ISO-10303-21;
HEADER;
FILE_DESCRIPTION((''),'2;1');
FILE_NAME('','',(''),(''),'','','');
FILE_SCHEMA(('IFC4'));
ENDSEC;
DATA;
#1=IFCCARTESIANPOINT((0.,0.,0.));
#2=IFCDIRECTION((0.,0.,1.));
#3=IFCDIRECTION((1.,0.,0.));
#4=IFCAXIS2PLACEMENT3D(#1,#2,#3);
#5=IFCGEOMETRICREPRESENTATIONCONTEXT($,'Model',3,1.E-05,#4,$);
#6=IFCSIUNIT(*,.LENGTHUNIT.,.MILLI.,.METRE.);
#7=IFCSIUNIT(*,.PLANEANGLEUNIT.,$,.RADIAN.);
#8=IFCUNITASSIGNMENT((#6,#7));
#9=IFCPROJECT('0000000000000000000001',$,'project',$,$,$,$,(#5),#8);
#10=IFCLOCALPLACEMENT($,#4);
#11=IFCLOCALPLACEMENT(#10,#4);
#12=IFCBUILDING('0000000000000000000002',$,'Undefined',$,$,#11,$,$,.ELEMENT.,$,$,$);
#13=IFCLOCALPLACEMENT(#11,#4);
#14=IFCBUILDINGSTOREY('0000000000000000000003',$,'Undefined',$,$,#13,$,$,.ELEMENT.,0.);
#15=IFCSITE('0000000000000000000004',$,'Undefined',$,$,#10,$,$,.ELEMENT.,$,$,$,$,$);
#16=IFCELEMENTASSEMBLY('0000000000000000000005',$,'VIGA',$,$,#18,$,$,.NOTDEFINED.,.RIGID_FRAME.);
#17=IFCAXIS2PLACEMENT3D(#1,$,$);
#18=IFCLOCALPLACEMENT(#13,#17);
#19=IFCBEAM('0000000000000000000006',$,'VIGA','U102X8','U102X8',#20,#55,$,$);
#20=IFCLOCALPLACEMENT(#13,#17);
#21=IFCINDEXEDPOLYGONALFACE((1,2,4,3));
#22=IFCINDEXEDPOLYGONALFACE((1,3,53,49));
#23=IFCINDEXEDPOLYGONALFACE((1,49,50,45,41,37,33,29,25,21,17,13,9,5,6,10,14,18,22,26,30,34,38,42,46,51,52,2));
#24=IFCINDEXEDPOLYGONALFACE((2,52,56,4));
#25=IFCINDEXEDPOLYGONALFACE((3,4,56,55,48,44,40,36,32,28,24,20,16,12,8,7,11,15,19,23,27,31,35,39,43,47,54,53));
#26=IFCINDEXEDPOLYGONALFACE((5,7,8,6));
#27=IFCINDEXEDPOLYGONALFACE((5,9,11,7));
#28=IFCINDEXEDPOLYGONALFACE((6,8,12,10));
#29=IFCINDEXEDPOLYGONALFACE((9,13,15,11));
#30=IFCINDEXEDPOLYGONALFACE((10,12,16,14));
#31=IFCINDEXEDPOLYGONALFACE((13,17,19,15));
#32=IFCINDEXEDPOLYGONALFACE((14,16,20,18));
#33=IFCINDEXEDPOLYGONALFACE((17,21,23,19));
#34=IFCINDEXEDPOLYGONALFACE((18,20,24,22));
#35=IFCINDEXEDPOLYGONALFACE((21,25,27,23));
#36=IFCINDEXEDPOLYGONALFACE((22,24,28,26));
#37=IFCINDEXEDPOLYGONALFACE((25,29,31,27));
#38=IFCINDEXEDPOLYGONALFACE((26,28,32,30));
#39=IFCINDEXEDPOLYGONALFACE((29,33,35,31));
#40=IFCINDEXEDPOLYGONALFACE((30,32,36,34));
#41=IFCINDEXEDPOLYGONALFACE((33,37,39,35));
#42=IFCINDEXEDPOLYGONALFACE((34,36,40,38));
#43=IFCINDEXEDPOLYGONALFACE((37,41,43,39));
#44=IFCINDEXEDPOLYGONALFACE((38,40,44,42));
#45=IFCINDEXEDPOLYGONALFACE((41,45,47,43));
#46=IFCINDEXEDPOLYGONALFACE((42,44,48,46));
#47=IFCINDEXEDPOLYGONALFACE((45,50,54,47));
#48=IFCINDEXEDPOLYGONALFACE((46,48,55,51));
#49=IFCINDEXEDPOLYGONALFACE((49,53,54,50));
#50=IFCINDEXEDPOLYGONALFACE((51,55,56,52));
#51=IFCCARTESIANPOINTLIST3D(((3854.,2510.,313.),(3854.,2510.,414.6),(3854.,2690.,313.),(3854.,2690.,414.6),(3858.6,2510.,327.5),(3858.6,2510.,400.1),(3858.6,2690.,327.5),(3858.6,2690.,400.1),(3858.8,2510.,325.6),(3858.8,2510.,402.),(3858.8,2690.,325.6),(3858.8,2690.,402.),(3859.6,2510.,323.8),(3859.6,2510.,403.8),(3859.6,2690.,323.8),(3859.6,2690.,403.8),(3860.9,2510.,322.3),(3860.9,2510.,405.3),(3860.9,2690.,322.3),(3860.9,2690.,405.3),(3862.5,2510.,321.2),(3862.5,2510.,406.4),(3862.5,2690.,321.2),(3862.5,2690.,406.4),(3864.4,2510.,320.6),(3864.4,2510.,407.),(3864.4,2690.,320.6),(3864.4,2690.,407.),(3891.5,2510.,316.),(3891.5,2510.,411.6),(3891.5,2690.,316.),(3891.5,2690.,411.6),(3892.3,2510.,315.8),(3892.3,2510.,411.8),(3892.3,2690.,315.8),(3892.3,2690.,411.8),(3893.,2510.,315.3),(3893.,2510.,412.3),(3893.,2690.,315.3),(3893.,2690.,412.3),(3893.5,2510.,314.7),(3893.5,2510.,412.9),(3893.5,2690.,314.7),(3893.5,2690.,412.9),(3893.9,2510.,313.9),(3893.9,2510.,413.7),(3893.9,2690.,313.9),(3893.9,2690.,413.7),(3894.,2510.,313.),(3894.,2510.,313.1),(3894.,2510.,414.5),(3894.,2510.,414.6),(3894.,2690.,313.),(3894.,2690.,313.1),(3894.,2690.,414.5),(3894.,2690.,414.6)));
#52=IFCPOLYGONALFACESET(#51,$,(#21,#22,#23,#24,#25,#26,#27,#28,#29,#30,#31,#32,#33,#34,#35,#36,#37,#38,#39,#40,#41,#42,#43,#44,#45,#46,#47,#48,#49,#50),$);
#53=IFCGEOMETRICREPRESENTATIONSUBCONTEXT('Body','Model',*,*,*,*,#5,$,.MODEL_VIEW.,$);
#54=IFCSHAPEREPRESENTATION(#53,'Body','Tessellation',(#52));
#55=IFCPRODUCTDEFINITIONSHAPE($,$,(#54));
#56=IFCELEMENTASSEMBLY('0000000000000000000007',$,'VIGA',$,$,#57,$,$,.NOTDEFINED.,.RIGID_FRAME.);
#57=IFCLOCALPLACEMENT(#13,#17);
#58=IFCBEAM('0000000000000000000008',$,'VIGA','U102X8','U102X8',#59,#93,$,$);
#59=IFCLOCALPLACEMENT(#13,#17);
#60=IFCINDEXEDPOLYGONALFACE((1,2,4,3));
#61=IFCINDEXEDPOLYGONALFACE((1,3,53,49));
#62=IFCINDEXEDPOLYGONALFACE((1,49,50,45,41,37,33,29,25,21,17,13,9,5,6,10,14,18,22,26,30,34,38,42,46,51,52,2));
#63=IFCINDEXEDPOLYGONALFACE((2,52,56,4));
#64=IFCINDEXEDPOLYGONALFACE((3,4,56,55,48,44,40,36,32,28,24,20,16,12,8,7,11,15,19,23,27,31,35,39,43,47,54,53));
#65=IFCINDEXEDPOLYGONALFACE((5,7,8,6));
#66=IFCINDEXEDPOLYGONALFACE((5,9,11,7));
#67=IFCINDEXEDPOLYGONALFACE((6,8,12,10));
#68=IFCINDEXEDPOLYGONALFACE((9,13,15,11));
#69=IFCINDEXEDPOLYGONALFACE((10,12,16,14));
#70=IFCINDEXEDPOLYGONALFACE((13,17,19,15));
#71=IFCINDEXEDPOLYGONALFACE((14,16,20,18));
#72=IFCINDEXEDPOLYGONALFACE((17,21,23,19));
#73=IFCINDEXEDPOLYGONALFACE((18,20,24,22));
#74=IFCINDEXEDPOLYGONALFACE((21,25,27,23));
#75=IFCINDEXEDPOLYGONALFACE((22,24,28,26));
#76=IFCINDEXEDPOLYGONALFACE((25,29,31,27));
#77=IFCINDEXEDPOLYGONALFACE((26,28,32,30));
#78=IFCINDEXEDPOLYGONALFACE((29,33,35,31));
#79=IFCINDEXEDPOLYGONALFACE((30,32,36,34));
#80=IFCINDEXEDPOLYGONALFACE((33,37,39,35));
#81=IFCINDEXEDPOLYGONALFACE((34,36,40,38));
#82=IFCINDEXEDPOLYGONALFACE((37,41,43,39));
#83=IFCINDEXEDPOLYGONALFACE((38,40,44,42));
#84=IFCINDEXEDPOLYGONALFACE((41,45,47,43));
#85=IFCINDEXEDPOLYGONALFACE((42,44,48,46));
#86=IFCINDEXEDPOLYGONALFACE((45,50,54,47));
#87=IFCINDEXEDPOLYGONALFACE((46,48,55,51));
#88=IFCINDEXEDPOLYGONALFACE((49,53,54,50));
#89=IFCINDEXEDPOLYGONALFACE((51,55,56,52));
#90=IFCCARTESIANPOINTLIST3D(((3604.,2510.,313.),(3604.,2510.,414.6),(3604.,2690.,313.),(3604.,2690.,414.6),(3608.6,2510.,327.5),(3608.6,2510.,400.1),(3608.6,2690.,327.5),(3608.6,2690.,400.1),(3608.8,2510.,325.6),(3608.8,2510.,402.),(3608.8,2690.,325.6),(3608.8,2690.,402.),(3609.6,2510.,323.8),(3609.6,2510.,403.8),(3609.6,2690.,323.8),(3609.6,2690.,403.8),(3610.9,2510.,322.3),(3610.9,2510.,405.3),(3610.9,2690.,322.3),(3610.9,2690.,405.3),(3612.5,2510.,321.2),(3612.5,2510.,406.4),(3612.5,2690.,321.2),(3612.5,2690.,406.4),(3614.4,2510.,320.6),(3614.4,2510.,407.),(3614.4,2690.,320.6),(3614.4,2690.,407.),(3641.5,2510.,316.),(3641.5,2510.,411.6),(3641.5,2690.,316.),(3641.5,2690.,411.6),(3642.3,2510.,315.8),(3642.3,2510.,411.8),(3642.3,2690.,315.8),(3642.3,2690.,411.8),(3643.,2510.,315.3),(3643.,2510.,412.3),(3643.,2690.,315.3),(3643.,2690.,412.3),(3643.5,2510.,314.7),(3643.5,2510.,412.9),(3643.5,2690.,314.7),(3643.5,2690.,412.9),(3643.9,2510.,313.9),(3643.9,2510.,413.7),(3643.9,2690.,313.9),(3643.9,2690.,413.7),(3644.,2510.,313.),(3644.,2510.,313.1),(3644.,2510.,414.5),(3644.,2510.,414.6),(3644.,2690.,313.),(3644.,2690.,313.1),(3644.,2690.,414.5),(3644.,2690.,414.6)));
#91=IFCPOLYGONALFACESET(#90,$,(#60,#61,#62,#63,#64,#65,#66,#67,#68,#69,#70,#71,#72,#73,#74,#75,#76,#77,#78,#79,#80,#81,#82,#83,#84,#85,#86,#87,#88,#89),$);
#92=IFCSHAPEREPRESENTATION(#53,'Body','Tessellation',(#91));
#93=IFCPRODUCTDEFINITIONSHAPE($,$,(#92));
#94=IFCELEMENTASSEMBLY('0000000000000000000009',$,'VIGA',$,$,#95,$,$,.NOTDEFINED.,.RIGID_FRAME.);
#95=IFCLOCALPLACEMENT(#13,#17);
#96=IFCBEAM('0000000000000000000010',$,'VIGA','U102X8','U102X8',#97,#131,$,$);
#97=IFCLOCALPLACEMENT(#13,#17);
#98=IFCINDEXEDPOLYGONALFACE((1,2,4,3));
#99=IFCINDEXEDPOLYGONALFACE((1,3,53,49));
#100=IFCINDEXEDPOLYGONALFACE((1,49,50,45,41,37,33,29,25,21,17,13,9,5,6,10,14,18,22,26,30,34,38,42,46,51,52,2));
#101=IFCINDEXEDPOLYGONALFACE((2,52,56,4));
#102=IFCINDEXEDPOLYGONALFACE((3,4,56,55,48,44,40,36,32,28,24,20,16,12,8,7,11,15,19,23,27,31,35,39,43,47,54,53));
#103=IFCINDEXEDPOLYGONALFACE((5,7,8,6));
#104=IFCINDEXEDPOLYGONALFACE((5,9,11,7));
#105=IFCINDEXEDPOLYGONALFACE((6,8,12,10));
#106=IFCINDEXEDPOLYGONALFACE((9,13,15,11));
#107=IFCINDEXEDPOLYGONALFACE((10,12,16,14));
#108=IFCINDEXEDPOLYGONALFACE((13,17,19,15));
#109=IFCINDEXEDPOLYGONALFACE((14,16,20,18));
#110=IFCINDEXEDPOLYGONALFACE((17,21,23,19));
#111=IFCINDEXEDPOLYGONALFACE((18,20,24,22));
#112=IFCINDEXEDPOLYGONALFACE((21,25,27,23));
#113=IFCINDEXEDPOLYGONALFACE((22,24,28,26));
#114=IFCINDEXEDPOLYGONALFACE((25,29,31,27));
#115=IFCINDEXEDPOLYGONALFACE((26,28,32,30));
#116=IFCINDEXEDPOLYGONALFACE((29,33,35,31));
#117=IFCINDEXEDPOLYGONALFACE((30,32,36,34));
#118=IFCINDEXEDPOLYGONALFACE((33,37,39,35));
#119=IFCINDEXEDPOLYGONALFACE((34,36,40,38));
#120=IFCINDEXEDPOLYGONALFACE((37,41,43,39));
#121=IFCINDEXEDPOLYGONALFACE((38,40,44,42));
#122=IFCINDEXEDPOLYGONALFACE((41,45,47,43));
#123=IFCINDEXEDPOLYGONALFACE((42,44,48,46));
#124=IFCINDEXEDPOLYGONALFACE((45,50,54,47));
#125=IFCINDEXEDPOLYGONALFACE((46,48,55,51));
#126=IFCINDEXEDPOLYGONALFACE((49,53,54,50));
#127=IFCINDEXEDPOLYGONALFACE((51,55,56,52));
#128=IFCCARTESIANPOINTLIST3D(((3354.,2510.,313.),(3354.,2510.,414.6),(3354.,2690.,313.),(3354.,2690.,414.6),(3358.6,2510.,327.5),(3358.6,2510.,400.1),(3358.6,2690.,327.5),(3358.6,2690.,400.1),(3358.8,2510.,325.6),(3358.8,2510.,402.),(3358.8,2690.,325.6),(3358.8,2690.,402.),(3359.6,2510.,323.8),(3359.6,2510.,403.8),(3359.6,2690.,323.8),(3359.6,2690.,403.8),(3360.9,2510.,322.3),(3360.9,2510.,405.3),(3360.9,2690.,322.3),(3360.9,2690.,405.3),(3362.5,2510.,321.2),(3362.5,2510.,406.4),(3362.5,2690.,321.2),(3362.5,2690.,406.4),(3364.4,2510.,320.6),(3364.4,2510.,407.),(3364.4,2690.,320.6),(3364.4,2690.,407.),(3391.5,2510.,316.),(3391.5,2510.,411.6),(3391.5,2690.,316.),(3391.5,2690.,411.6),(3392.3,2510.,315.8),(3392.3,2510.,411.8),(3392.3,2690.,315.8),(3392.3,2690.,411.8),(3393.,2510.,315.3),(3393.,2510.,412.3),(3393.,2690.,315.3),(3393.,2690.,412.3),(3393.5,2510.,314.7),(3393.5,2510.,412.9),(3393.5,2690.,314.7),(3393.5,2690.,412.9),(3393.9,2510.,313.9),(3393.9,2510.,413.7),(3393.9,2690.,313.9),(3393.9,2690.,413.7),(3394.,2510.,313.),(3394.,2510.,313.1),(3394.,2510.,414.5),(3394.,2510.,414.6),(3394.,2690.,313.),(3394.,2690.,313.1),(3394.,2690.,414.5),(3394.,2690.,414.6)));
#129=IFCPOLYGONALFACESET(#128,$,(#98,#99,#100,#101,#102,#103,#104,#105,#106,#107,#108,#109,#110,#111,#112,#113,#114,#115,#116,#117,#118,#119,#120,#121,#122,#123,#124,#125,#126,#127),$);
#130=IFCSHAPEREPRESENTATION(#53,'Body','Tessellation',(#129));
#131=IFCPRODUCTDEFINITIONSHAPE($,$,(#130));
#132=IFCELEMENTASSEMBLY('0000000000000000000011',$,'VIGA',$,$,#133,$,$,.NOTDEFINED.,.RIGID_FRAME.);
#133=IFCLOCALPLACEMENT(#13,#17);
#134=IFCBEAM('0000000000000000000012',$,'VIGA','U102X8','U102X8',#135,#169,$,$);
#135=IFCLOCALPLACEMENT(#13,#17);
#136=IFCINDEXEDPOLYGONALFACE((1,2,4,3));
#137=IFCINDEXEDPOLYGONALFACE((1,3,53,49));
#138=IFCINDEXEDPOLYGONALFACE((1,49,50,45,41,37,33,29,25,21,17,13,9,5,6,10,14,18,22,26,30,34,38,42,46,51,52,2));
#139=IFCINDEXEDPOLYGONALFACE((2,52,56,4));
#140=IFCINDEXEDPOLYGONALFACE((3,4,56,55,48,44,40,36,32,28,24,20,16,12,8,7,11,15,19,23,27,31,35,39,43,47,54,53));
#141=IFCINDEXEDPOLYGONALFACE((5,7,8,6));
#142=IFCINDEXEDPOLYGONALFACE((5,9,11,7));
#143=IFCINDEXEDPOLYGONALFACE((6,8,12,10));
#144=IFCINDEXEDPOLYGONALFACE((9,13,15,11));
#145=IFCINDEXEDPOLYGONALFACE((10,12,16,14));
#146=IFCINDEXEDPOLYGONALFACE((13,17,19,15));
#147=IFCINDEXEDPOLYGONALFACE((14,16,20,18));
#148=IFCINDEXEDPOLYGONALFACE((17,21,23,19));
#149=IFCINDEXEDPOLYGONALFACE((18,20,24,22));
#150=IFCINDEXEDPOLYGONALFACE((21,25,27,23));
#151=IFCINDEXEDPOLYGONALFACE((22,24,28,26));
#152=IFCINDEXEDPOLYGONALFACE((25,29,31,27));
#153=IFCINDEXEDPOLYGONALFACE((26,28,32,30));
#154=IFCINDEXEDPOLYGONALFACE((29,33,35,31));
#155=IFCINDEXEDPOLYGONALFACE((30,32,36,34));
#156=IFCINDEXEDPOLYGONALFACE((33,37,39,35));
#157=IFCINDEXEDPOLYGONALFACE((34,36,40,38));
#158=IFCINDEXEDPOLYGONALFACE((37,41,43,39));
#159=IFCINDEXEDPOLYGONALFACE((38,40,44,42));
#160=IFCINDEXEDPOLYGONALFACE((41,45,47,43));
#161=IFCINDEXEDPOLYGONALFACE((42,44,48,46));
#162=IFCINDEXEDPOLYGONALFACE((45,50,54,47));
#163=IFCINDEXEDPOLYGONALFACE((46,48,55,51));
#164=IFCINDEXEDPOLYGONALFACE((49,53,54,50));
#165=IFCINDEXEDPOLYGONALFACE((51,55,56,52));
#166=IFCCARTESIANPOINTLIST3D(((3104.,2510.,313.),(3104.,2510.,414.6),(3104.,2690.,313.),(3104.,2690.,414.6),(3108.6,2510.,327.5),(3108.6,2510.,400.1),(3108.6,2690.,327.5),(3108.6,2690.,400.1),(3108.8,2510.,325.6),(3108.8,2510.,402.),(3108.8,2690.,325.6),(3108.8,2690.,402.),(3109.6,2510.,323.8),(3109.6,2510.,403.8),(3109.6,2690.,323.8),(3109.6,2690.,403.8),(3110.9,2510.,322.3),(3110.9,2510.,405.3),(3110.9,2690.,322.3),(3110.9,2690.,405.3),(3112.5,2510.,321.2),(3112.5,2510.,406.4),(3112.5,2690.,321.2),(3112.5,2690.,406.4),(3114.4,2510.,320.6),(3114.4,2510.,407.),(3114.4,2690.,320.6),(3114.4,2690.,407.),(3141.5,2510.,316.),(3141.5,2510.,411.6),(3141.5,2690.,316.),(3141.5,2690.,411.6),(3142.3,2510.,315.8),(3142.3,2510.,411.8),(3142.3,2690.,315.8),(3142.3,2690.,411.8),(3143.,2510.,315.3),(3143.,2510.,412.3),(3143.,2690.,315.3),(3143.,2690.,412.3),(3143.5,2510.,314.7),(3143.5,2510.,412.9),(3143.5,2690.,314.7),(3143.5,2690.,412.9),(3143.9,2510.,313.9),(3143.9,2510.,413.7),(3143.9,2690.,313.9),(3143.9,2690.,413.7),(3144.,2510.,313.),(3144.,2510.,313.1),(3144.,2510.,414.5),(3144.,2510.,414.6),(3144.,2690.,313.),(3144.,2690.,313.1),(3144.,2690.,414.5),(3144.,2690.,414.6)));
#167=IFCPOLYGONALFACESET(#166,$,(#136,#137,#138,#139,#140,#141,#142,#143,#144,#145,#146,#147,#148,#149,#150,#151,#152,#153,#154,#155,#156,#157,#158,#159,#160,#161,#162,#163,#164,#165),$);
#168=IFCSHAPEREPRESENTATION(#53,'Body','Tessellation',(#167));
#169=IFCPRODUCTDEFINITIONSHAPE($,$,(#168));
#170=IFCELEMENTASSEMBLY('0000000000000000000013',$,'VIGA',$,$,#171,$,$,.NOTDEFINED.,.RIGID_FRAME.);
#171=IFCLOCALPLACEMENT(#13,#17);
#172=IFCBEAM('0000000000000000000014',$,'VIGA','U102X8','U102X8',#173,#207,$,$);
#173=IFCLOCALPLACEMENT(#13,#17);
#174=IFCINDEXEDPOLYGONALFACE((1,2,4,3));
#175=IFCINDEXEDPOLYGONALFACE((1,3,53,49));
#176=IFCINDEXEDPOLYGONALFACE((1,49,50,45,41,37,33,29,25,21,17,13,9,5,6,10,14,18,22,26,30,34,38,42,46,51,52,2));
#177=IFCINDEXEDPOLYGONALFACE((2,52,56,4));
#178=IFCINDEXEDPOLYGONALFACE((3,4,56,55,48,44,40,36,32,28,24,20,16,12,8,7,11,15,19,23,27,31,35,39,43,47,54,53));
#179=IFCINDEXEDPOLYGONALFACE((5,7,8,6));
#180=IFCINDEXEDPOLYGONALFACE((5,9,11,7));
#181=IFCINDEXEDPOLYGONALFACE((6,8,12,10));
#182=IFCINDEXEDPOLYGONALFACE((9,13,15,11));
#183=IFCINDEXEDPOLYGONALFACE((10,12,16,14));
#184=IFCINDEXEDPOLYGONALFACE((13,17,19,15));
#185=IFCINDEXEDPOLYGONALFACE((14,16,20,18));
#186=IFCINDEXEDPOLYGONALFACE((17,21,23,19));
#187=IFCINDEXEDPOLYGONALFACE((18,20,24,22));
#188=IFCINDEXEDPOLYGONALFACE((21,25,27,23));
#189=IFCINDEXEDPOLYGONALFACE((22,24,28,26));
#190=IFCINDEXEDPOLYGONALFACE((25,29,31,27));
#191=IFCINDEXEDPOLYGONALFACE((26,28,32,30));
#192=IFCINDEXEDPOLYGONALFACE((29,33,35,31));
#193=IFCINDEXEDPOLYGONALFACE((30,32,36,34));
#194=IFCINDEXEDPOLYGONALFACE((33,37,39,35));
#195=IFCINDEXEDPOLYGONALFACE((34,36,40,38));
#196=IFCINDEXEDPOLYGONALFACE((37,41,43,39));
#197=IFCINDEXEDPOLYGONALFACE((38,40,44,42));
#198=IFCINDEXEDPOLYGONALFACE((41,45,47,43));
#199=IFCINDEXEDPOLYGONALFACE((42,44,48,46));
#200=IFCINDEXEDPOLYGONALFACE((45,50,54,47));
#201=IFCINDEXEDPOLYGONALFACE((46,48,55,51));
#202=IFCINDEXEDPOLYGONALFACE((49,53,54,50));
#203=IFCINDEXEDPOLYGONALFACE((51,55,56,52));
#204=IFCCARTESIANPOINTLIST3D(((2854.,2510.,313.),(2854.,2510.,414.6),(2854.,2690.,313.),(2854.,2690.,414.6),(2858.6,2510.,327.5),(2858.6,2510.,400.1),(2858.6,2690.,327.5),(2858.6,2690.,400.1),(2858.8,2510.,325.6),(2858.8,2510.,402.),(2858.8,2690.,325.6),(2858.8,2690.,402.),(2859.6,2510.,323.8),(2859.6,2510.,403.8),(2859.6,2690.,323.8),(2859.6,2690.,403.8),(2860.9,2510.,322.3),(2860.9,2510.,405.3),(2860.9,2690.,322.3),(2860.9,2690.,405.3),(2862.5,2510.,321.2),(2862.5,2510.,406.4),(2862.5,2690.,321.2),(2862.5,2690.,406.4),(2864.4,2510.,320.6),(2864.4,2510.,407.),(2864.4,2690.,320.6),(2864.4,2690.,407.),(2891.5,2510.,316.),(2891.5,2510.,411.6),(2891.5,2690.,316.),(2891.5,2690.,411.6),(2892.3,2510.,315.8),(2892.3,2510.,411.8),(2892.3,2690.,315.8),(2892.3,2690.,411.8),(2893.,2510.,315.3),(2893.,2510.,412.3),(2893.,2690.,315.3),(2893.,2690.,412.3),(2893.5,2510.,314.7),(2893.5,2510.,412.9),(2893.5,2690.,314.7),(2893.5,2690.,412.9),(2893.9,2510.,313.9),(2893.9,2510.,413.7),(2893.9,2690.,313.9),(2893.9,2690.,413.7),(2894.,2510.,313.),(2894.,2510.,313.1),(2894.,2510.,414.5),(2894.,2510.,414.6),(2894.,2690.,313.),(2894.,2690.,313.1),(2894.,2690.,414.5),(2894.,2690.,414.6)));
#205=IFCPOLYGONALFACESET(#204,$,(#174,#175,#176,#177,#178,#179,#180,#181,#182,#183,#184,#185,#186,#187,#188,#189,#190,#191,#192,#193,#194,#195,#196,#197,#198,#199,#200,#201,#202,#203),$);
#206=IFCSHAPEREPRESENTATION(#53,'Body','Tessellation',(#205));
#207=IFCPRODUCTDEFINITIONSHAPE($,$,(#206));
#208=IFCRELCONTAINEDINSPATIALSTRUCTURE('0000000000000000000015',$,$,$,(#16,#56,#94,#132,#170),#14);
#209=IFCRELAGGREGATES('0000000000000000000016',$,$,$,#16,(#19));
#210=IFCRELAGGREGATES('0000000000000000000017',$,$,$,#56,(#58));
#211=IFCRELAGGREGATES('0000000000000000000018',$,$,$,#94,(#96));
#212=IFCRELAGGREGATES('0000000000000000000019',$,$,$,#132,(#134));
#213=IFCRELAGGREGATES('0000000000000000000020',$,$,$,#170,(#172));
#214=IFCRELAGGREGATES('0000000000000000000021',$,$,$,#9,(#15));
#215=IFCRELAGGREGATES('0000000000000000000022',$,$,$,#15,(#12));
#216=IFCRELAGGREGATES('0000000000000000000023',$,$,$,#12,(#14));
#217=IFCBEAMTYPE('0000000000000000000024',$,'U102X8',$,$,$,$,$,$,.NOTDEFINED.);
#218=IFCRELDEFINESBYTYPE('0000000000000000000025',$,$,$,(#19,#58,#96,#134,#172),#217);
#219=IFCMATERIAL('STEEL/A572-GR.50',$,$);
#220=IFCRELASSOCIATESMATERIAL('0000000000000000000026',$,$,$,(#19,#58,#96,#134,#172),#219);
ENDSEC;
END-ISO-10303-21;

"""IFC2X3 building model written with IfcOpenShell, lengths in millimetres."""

from ifc_helpers import new_model, si_unit, frame, origin_with_axes, origin_2d_with_axis, place, context, subcontext, project, spatial, u_section, extrude, material, type_object, element, aggregate, save


model = new_model("IFC2X3")

# Units and contexts
model_context = context("Model", 3, precision=1e-05, world=origin_with_axes())
body_context = subcontext(model_context, "Body", "Model", "MODEL_VIEW")
ifc_project = project(units=[si_unit("LENGTHUNIT", "METRE", prefix="MILLI"), si_unit("PLANEANGLEUNIT", "RADIAN")], contexts=[model_context])

# Site, building, storey
site_placement = place(None, origin_with_axes())
site = spatial("IfcSite", under=ifc_project, at=site_placement, Name="Undefined", CompositionType="ELEMENT")
building_placement = place(site_placement, origin_with_axes())
building = spatial("IfcBuilding", under=site, at=building_placement, Name="Undefined", CompositionType="ELEMENT")
storey_placement = place(building_placement, origin_with_axes())
storey = spatial("IfcBuildingStorey", under=building, at=storey_placement, Name="Undefined", CompositionType="ELEMENT", Elevation=0.0)

# Element assemblies, beams
ifc_material_1 = material(Name="STEEL/A572-GR.50")
beam_type_1 = type_object("IfcBeamType", Name="U102X8", PredefinedType="NOTDEFINED")
assembly_1_placement = place(storey_placement, origin_with_axes())
assembly_1 = element("IfcElementAssembly", 1, at=assembly_1_placement, inside=storey, Name="VIGA", AssemblyPlace="NOTDEFINED", PredefinedType="RIGID_FRAME")
beam_1_placement = place(assembly_1_placement, frame((3874.0, 2510.0, 363.8), z_axis=(0.0, 0.0, 1.0), x_axis=(0.0, 1.0, 0.0)))
beam_1 = element("IfcBeam", 2, at=beam_1_placement, type_object=beam_type_1, material=ifc_material_1, Name="VIGA", Description="U102X8", ObjectType="U102X8", context=body_context, shape_type="SweptSolid", body=[
    extrude(u_section(Depth=101.6, FlangeWidth=40.0, WebThickness=4.6, FlangeThickness=6.0, FilletRadius=7.0, EdgeRadius=3.0, FlangeSlope=0.16839, at=origin_2d_with_axis()), frame((180.0, 0.0, 0.0), z_axis=(-1.0, 0.0, 0.0), x_axis=(0.0, -1.0, 0.0)), (0.0, 0.0, 1.0), 180.0),
])
aggregate(assembly_1, [beam_1])
assembly_2_placement = place(storey_placement, origin_with_axes())
assembly_2 = element("IfcElementAssembly", 3, at=assembly_2_placement, inside=storey, Name="VIGA", AssemblyPlace="NOTDEFINED", PredefinedType="RIGID_FRAME")
beam_2_placement = place(assembly_2_placement, frame((3624.0, 2510.0, 363.8), z_axis=(0.0, 0.0, 1.0), x_axis=(0.0, 1.0, 0.0)))
beam_2 = element("IfcBeam", 4, at=beam_2_placement, type_object=beam_type_1, material=ifc_material_1, Name="VIGA", Description="U102X8", ObjectType="U102X8", context=body_context, shape_type="SweptSolid", body=[
    extrude(u_section(Depth=101.6, FlangeWidth=40.0, WebThickness=4.6, FlangeThickness=6.0, FilletRadius=7.0, EdgeRadius=3.0, FlangeSlope=0.16839, at=origin_2d_with_axis()), frame((180.0, 0.0, 0.0), z_axis=(-1.0, 0.0, 0.0), x_axis=(0.0, -1.0, 0.0)), (0.0, 0.0, 1.0), 180.0),
])
aggregate(assembly_2, [beam_2])
assembly_3_placement = place(storey_placement, origin_with_axes())
assembly_3 = element("IfcElementAssembly", 5, at=assembly_3_placement, inside=storey, Name="VIGA", AssemblyPlace="NOTDEFINED", PredefinedType="RIGID_FRAME")
beam_3_placement = place(assembly_3_placement, frame((3374.0, 2510.0, 363.8), z_axis=(0.0, 0.0, 1.0), x_axis=(0.0, 1.0, 0.0)))
beam_3 = element("IfcBeam", 6, at=beam_3_placement, type_object=beam_type_1, material=ifc_material_1, Name="VIGA", Description="U102X8", ObjectType="U102X8", context=body_context, shape_type="SweptSolid", body=[
    extrude(u_section(Depth=101.6, FlangeWidth=40.0, WebThickness=4.6, FlangeThickness=6.0, FilletRadius=7.0, EdgeRadius=3.0, FlangeSlope=0.16839, at=origin_2d_with_axis()), frame((180.0, 0.0, 0.0), z_axis=(-1.0, 0.0, 0.0), x_axis=(0.0, -1.0, 0.0)), (0.0, 0.0, 1.0), 180.0),
])
aggregate(assembly_3, [beam_3])
assembly_4_placement = place(storey_placement, origin_with_axes())
assembly_4 = element("IfcElementAssembly", 7, at=assembly_4_placement, inside=storey, Name="VIGA", AssemblyPlace="NOTDEFINED", PredefinedType="RIGID_FRAME")
beam_4_placement = place(assembly_4_placement, frame((3124.0, 2510.0, 363.8), z_axis=(0.0, 0.0, 1.0), x_axis=(0.0, 1.0, 0.0)))
beam_4 = element("IfcBeam", 8, at=beam_4_placement, type_object=beam_type_1, material=ifc_material_1, Name="VIGA", Description="U102X8", ObjectType="U102X8", context=body_context, shape_type="SweptSolid", body=[
    extrude(u_section(Depth=101.6, FlangeWidth=40.0, WebThickness=4.6, FlangeThickness=6.0, FilletRadius=7.0, EdgeRadius=3.0, FlangeSlope=0.16839, at=origin_2d_with_axis()), frame((180.0, 0.0, 0.0), z_axis=(-1.0, 0.0, 0.0), x_axis=(0.0, -1.0, 0.0)), (0.0, 0.0, 1.0), 180.0),
])
aggregate(assembly_4, [beam_4])
assembly_5_placement = place(storey_placement, origin_with_axes())
assembly_5 = element("IfcElementAssembly", 9, at=assembly_5_placement, inside=storey, Name="VIGA", AssemblyPlace="NOTDEFINED", PredefinedType="RIGID_FRAME")
beam_5_placement = place(assembly_5_placement, frame((2874.0, 2510.0, 363.8), z_axis=(0.0, 0.0, 1.0), x_axis=(0.0, 1.0, 0.0)))
beam_5 = element("IfcBeam", 10, at=beam_5_placement, type_object=beam_type_1, material=ifc_material_1, Name="VIGA", Description="U102X8", ObjectType="U102X8", context=body_context, shape_type="SweptSolid", body=[
    extrude(u_section(Depth=101.6, FlangeWidth=40.0, WebThickness=4.6, FlangeThickness=6.0, FilletRadius=7.0, EdgeRadius=3.0, FlangeSlope=0.16839, at=origin_2d_with_axis()), frame((180.0, 0.0, 0.0), z_axis=(-1.0, 0.0, 0.0), x_axis=(0.0, -1.0, 0.0)), (0.0, 0.0, 1.0), 180.0),
])
aggregate(assembly_5, [beam_5])

save(model, "model.ifc")
